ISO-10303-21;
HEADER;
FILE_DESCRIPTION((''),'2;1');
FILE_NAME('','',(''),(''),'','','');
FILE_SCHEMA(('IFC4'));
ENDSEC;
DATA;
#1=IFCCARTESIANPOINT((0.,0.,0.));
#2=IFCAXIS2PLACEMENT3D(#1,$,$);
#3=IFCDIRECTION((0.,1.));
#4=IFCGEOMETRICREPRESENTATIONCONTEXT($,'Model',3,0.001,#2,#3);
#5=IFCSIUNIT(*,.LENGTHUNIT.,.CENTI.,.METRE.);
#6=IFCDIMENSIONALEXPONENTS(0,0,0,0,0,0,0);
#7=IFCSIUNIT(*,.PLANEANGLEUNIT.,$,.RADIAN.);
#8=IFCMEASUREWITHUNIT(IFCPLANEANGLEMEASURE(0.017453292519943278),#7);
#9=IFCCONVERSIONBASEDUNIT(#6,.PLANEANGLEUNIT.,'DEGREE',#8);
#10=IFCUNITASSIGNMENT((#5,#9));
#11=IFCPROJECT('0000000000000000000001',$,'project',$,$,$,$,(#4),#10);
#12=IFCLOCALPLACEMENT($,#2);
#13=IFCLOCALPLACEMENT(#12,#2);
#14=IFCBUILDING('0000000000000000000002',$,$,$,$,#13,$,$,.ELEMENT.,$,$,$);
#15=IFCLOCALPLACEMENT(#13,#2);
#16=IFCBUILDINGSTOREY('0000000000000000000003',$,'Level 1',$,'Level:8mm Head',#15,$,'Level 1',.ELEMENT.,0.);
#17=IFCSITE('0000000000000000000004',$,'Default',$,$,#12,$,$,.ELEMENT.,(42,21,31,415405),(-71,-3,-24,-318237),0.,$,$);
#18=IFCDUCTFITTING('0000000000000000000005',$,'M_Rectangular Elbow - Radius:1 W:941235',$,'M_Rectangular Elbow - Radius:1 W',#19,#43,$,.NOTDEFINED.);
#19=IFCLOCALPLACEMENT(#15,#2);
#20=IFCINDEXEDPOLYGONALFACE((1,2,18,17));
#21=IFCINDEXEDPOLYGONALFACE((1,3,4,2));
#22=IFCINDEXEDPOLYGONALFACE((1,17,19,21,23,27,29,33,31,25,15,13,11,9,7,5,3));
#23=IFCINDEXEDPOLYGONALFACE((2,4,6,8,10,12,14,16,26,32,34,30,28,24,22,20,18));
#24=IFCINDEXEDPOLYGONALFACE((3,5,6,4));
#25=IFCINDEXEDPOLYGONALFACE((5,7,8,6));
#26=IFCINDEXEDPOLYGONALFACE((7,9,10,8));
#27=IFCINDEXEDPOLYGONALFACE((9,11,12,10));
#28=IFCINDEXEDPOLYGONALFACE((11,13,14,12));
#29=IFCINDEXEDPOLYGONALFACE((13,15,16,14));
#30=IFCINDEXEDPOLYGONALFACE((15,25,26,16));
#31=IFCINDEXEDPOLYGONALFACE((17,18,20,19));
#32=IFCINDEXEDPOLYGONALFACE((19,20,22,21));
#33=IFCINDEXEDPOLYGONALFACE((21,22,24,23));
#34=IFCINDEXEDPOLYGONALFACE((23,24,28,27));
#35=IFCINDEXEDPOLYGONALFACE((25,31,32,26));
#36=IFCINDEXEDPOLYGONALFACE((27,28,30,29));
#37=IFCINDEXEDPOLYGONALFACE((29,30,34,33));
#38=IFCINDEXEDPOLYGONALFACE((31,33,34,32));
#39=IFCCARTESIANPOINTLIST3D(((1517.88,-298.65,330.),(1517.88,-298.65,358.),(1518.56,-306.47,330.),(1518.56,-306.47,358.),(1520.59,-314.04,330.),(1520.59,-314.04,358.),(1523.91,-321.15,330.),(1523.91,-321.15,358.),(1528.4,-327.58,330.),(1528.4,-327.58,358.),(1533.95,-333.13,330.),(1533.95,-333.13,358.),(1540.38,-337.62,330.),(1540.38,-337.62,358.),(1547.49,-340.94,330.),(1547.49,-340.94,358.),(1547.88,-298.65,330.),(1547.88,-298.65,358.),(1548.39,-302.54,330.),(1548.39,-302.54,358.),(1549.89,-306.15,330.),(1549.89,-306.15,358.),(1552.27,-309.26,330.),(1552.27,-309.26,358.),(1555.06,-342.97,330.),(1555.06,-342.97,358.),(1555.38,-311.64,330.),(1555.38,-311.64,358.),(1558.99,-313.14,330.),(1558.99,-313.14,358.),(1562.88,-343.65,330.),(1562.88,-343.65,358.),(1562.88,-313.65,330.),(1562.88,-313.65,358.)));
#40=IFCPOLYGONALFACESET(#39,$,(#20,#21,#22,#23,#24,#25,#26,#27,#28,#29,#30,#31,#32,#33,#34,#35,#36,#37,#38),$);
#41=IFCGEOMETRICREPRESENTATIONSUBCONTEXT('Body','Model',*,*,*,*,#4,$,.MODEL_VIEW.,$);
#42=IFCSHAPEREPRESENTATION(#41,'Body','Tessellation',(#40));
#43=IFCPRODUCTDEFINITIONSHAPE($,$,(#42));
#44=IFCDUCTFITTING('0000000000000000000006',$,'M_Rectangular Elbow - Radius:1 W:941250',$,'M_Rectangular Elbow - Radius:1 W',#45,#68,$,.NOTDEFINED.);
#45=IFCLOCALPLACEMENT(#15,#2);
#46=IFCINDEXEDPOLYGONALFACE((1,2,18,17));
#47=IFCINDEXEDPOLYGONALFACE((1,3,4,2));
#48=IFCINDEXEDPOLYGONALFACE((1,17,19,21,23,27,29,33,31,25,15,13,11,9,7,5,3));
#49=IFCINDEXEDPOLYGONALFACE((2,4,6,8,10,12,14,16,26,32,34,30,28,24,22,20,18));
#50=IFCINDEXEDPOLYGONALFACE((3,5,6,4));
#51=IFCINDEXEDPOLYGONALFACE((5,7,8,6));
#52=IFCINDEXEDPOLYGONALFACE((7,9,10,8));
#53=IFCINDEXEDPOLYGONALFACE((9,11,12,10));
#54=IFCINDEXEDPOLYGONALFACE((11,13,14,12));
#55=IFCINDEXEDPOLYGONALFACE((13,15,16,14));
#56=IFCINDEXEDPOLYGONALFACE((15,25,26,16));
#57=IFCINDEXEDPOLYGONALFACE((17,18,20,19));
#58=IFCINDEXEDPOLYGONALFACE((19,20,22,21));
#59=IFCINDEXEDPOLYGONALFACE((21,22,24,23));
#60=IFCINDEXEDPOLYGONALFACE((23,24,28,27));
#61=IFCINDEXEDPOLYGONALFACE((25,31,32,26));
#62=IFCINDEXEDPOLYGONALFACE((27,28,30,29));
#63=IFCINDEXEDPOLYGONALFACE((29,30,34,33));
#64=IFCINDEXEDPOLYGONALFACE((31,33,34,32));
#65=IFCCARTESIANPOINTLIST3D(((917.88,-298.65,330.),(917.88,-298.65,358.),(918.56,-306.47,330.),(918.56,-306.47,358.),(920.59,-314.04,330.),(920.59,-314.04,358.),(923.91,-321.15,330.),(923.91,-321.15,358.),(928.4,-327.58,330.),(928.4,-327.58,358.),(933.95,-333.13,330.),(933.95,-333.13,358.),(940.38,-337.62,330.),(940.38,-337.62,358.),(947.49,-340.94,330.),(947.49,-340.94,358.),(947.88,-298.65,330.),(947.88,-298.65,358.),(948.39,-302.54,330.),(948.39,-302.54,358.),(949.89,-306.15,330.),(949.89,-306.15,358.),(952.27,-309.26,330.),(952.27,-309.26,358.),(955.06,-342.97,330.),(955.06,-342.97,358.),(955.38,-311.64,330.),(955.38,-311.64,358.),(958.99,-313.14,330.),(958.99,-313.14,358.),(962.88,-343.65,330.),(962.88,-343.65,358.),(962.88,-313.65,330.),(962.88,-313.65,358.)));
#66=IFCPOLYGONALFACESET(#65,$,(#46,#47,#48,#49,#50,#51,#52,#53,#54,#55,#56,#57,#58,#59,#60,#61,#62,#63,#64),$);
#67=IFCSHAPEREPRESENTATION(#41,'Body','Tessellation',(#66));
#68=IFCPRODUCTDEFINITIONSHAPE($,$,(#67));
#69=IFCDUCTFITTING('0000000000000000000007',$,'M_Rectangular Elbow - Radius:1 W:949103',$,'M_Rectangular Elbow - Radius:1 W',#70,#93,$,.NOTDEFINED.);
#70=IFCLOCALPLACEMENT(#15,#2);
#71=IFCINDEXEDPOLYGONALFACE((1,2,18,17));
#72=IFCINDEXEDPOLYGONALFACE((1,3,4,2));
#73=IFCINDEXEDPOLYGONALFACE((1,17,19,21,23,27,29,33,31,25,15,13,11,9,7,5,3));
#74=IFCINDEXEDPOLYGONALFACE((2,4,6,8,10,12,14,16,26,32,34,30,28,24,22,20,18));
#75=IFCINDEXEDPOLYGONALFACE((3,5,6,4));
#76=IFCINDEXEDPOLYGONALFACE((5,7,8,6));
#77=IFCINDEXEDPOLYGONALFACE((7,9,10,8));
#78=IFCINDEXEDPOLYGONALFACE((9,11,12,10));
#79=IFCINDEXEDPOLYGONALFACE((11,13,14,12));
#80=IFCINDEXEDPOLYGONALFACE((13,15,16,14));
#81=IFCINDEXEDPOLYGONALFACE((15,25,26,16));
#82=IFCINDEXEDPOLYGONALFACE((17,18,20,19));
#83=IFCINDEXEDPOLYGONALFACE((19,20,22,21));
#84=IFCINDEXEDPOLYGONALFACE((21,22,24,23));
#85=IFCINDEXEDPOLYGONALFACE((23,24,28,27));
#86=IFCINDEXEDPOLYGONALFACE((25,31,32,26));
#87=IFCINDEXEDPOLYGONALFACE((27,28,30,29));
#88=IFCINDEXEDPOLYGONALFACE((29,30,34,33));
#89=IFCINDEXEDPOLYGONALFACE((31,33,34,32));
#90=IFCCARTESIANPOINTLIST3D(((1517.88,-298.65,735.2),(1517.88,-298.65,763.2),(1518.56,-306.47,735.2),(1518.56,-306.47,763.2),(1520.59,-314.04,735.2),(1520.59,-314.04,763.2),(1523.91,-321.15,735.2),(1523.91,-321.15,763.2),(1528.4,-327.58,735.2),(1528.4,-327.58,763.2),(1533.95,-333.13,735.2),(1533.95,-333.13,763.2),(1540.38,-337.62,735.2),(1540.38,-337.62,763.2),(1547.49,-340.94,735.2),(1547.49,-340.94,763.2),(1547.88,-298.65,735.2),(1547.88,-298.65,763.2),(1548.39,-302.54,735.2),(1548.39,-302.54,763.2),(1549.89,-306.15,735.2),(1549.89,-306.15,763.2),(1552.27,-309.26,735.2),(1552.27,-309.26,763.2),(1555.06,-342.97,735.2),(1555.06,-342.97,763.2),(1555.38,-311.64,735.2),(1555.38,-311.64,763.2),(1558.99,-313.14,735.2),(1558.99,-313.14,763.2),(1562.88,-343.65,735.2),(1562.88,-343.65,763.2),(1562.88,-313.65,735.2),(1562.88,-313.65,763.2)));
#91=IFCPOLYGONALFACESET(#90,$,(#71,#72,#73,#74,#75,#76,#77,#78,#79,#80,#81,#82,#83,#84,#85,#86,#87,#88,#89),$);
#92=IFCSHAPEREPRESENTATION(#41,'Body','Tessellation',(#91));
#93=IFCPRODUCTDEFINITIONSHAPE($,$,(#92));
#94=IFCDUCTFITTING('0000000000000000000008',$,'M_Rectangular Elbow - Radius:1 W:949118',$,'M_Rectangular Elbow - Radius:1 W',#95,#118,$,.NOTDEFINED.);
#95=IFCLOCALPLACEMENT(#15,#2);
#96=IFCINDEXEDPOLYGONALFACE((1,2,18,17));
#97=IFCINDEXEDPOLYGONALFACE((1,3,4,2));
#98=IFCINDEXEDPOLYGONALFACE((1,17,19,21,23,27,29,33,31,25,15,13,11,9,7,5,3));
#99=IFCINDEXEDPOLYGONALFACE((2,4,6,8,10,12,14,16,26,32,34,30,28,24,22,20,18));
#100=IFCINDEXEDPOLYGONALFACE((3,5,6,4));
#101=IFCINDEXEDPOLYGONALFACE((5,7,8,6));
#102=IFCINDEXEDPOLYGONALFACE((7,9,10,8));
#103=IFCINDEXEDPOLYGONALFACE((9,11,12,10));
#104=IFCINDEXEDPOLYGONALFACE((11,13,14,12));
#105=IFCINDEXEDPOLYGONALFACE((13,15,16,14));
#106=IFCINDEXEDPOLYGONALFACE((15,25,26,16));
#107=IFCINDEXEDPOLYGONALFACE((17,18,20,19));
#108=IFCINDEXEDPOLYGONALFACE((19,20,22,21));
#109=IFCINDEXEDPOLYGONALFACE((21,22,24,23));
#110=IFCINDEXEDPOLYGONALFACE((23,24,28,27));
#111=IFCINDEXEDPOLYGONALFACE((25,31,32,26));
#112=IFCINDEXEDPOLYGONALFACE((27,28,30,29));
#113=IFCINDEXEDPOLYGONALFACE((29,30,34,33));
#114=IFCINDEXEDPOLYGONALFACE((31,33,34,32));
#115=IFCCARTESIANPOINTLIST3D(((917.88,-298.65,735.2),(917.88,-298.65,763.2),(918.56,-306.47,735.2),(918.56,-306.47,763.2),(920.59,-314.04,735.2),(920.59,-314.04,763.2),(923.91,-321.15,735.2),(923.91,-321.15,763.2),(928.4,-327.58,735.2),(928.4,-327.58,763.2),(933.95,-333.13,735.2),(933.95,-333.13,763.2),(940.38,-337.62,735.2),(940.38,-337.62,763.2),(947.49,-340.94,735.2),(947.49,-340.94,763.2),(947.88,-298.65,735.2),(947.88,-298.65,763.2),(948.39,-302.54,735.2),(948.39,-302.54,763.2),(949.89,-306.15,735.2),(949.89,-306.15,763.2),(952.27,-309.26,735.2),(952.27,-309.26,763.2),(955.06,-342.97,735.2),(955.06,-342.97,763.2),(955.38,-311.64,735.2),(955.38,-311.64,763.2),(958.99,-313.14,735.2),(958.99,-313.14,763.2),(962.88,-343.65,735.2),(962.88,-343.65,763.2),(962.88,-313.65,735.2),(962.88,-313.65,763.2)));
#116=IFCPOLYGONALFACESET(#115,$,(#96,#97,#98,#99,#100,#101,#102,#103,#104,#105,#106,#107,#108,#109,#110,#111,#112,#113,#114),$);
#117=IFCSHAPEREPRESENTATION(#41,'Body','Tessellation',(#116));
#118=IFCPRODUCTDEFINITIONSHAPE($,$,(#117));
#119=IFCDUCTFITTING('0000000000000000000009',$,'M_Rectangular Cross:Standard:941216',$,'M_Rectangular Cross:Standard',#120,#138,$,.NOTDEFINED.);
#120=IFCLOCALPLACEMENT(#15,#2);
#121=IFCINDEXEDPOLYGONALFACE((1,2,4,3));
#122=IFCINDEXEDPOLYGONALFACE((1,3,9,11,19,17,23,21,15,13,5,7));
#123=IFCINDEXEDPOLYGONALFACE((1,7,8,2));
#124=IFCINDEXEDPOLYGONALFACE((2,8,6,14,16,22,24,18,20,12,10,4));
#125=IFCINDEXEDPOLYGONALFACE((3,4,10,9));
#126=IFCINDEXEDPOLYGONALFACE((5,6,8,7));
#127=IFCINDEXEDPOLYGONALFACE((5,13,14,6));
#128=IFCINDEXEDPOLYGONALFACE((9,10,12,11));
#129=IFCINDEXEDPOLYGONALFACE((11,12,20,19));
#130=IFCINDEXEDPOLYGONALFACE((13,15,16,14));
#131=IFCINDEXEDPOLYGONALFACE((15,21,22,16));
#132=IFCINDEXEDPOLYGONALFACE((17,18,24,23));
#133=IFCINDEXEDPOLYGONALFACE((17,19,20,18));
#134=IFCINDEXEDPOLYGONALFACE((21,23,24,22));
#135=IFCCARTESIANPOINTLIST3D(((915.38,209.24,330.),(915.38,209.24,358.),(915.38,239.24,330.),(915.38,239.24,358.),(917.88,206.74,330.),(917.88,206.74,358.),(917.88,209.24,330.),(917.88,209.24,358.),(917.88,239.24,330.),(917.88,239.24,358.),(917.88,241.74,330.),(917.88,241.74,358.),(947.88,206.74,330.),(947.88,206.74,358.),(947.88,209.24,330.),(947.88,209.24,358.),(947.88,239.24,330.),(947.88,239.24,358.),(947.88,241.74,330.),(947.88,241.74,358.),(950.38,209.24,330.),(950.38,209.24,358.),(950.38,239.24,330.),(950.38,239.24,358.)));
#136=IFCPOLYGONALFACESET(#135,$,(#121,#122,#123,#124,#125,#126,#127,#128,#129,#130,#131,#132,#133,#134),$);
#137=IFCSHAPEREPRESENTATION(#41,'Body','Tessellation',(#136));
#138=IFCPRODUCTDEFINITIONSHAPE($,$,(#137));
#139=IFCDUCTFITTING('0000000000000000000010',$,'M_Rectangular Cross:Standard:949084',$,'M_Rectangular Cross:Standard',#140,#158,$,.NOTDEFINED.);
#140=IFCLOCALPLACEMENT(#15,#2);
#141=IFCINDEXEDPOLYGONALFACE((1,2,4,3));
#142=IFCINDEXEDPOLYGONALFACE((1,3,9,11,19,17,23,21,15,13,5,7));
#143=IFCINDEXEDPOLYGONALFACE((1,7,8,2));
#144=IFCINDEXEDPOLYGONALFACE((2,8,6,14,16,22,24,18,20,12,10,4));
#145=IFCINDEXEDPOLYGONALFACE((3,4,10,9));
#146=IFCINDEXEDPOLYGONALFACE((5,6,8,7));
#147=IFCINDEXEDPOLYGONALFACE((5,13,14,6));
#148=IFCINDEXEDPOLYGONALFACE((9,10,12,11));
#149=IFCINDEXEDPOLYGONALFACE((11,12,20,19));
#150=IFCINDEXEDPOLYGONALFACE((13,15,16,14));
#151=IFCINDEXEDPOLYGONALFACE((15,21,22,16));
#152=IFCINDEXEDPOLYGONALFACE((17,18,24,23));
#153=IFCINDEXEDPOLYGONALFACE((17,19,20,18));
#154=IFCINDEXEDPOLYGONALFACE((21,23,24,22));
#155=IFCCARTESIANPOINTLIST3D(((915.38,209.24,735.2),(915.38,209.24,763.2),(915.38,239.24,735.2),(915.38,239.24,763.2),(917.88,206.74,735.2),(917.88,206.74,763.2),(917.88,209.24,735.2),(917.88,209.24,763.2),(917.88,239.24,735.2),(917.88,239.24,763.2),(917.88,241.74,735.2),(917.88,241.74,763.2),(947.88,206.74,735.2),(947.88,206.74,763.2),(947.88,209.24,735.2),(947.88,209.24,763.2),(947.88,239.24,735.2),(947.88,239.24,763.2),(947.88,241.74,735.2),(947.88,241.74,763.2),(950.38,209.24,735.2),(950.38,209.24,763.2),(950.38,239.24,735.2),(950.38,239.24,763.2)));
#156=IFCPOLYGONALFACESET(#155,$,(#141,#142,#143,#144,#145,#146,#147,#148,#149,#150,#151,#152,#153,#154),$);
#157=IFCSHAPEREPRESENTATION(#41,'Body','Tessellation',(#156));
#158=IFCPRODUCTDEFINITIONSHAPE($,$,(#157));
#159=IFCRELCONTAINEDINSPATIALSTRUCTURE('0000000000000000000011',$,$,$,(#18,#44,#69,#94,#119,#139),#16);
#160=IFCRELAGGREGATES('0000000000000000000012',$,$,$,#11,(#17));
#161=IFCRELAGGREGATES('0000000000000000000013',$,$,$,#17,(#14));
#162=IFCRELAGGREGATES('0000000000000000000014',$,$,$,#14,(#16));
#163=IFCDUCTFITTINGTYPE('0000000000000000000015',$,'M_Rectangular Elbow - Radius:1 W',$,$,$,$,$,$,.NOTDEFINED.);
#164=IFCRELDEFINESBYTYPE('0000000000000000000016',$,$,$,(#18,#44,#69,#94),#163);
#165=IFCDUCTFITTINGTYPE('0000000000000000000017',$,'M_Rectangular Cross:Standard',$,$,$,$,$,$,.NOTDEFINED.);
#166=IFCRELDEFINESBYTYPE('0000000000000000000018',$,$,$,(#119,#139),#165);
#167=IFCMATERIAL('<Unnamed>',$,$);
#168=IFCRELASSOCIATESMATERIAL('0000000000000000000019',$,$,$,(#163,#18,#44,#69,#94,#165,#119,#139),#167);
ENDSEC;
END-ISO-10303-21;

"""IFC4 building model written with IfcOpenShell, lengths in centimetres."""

from ifc_helpers import new_model, entity, si_unit, converted_unit, direction, frame, origin, place, context, subcontext, project, spatial, line, arc, indexed_curve, outline, extrude, source, transform, mapped, material, type_object, type_shapes, element, save


model = new_model("IFC4")

# Units and contexts
model_context = context("Model", 3, precision=0.001, world=origin(), true_north=direction((0.0, 1.0)))
body_context = subcontext(model_context, "Body", "Model", "MODEL_VIEW")
ifc_project = project(units=[si_unit("LENGTHUNIT", "METRE", prefix="CENTI"), converted_unit("PLANEANGLEUNIT", "DEGREE", entity("IfcPlaneAngleMeasure", 0.017453292519943278), si_unit("PLANEANGLEUNIT", "RADIAN"), dimensions=[0, 0, 0, 0, 0, 0, 0])], contexts=[model_context])

# Site, building, storey
site_placement = place(None, origin())
site = spatial("IfcSite", under=ifc_project, at=site_placement, Name="Default", CompositionType="ELEMENT", RefLatitude=(42, 21, 31, 415405), RefLongitude=(-71, -3, -24, -318237), RefElevation=0.0)
building_placement = place(site_placement, origin())
building = spatial("IfcBuilding", under=site, at=building_placement, CompositionType="ELEMENT")
storey_placement = place(building_placement, origin())
storey = spatial("IfcBuildingStorey", under=building, at=storey_placement, Name="Level 1", ObjectType="Level:8mm Head", LongName="Level 1", CompositionType="ELEMENT", Elevation=0.0)

# Duct fittings
ifc_material = material(Name="<Unnamed>")
duct_fitting_type_1 = type_object("IfcDuctFittingType", Name="M_Rectangular Elbow - Radius:1 W", PredefinedType="NOTDEFINED", material=ifc_material)
shared_shape_1 = source(origin(), body_context, "Body", "SweptSolid", [
    extrude(outline(indexed_curve([(-15.0, -30.0), (16.82, -16.82), (30.0, 15.0), (0.0, 15.0), (-4.39, 4.39), (-15.0, 0.0)], segments=[arc(1, 2, 3), line(3, 4), arc(4, 5, 6), line(6, 1)], self_intersect=False)), frame((-15.0, -15.0, -14.0), z_axis=(0.0, 0.0, 1.0), x_axis=(0.0, 1.0, 0.0)), (0.0, 0.0, 1.0), 28.0),
])
type_shapes(duct_fitting_type_1, [shared_shape_1])
for number, where, z_axis, x_axis, name in (
    (1, (1532.88, -328.65, 344.0), (0.0, 0.0, 1.0), (-1.0, 0.0, 0.0), "M_Rectangular Elbow - Radius:1 W:941235"),
    (2, (932.88, -328.65, 344.0), (0.0, 0.0, 1.0), (-1.0, 0.0, 0.0), "M_Rectangular Elbow - Radius:1 W:941250"),
    (3, (1532.88, -328.65, 749.2), (0.0, 0.0, 1.0), (-1.0, 0.0, 0.0), "M_Rectangular Elbow - Radius:1 W:949103"),
    (4, (932.88, -328.65, 749.2), (0.0, 0.0, 1.0), (-1.0, 0.0, 0.0), "M_Rectangular Elbow - Radius:1 W:949118"),
):
    element("IfcDuctFitting", number, at=place(storey_placement, frame(where, z_axis=z_axis, x_axis=x_axis)), inside=storey, type_object=duct_fitting_type_1, material=ifc_material, Name=name, ObjectType="M_Rectangular Elbow - Radius:1 W", PredefinedType="NOTDEFINED", context=body_context, shape_type="MappedRepresentation", body=[
        mapped(shared_shape_1, transform((0.0, 0.0, 0.0), scale=1.0)),
    ])
duct_fitting_type_2 = type_object("IfcDuctFittingType", Name="M_Rectangular Cross:Standard", PredefinedType="NOTDEFINED", material=ifc_material)
shared_shape_2 = source(origin(), body_context, "Body", "SweptSolid", [
    extrude(outline(indexed_curve([(-15.0, -17.5), (15.0, -17.5), (15.0, -15.0), (17.5, -15.0), (17.5, 15.0), (15.0, 15.0), (15.0, 17.5), (-15.0, 17.5), (-15.0, 15.0), (-17.5, 15.0), (-17.5, -15.0), (-15.0, -15.0), (-15.0, -17.5)], self_intersect=False)), frame((0.0, 0.0, -14.0), z_axis=(0.0, 0.0, 1.0), x_axis=(-1.0, 0.0, 0.0)), (0.0, 0.0, 1.0), 28.0),
])
type_shapes(duct_fitting_type_2, [shared_shape_2])
for number, where, z_axis, x_axis, name in (
    (5, (932.88, 224.24, 344.0), (0.0, 0.0, 1.0), (-1.0, 0.0, 0.0), "M_Rectangular Cross:Standard:941216"),
    (6, (932.88, 224.24, 749.2), (0.0, 0.0, 1.0), (-1.0, 0.0, 0.0), "M_Rectangular Cross:Standard:949084"),
):
    element("IfcDuctFitting", number, at=place(storey_placement, frame(where, z_axis=z_axis, x_axis=x_axis)), inside=storey, type_object=duct_fitting_type_2, material=ifc_material, Name=name, ObjectType="M_Rectangular Cross:Standard", PredefinedType="NOTDEFINED", context=body_context, shape_type="MappedRepresentation", body=[
        mapped(shared_shape_2, transform((0.0, 0.0, 0.0), scale=1.0)),
    ])

save(model, "model.ifc")
